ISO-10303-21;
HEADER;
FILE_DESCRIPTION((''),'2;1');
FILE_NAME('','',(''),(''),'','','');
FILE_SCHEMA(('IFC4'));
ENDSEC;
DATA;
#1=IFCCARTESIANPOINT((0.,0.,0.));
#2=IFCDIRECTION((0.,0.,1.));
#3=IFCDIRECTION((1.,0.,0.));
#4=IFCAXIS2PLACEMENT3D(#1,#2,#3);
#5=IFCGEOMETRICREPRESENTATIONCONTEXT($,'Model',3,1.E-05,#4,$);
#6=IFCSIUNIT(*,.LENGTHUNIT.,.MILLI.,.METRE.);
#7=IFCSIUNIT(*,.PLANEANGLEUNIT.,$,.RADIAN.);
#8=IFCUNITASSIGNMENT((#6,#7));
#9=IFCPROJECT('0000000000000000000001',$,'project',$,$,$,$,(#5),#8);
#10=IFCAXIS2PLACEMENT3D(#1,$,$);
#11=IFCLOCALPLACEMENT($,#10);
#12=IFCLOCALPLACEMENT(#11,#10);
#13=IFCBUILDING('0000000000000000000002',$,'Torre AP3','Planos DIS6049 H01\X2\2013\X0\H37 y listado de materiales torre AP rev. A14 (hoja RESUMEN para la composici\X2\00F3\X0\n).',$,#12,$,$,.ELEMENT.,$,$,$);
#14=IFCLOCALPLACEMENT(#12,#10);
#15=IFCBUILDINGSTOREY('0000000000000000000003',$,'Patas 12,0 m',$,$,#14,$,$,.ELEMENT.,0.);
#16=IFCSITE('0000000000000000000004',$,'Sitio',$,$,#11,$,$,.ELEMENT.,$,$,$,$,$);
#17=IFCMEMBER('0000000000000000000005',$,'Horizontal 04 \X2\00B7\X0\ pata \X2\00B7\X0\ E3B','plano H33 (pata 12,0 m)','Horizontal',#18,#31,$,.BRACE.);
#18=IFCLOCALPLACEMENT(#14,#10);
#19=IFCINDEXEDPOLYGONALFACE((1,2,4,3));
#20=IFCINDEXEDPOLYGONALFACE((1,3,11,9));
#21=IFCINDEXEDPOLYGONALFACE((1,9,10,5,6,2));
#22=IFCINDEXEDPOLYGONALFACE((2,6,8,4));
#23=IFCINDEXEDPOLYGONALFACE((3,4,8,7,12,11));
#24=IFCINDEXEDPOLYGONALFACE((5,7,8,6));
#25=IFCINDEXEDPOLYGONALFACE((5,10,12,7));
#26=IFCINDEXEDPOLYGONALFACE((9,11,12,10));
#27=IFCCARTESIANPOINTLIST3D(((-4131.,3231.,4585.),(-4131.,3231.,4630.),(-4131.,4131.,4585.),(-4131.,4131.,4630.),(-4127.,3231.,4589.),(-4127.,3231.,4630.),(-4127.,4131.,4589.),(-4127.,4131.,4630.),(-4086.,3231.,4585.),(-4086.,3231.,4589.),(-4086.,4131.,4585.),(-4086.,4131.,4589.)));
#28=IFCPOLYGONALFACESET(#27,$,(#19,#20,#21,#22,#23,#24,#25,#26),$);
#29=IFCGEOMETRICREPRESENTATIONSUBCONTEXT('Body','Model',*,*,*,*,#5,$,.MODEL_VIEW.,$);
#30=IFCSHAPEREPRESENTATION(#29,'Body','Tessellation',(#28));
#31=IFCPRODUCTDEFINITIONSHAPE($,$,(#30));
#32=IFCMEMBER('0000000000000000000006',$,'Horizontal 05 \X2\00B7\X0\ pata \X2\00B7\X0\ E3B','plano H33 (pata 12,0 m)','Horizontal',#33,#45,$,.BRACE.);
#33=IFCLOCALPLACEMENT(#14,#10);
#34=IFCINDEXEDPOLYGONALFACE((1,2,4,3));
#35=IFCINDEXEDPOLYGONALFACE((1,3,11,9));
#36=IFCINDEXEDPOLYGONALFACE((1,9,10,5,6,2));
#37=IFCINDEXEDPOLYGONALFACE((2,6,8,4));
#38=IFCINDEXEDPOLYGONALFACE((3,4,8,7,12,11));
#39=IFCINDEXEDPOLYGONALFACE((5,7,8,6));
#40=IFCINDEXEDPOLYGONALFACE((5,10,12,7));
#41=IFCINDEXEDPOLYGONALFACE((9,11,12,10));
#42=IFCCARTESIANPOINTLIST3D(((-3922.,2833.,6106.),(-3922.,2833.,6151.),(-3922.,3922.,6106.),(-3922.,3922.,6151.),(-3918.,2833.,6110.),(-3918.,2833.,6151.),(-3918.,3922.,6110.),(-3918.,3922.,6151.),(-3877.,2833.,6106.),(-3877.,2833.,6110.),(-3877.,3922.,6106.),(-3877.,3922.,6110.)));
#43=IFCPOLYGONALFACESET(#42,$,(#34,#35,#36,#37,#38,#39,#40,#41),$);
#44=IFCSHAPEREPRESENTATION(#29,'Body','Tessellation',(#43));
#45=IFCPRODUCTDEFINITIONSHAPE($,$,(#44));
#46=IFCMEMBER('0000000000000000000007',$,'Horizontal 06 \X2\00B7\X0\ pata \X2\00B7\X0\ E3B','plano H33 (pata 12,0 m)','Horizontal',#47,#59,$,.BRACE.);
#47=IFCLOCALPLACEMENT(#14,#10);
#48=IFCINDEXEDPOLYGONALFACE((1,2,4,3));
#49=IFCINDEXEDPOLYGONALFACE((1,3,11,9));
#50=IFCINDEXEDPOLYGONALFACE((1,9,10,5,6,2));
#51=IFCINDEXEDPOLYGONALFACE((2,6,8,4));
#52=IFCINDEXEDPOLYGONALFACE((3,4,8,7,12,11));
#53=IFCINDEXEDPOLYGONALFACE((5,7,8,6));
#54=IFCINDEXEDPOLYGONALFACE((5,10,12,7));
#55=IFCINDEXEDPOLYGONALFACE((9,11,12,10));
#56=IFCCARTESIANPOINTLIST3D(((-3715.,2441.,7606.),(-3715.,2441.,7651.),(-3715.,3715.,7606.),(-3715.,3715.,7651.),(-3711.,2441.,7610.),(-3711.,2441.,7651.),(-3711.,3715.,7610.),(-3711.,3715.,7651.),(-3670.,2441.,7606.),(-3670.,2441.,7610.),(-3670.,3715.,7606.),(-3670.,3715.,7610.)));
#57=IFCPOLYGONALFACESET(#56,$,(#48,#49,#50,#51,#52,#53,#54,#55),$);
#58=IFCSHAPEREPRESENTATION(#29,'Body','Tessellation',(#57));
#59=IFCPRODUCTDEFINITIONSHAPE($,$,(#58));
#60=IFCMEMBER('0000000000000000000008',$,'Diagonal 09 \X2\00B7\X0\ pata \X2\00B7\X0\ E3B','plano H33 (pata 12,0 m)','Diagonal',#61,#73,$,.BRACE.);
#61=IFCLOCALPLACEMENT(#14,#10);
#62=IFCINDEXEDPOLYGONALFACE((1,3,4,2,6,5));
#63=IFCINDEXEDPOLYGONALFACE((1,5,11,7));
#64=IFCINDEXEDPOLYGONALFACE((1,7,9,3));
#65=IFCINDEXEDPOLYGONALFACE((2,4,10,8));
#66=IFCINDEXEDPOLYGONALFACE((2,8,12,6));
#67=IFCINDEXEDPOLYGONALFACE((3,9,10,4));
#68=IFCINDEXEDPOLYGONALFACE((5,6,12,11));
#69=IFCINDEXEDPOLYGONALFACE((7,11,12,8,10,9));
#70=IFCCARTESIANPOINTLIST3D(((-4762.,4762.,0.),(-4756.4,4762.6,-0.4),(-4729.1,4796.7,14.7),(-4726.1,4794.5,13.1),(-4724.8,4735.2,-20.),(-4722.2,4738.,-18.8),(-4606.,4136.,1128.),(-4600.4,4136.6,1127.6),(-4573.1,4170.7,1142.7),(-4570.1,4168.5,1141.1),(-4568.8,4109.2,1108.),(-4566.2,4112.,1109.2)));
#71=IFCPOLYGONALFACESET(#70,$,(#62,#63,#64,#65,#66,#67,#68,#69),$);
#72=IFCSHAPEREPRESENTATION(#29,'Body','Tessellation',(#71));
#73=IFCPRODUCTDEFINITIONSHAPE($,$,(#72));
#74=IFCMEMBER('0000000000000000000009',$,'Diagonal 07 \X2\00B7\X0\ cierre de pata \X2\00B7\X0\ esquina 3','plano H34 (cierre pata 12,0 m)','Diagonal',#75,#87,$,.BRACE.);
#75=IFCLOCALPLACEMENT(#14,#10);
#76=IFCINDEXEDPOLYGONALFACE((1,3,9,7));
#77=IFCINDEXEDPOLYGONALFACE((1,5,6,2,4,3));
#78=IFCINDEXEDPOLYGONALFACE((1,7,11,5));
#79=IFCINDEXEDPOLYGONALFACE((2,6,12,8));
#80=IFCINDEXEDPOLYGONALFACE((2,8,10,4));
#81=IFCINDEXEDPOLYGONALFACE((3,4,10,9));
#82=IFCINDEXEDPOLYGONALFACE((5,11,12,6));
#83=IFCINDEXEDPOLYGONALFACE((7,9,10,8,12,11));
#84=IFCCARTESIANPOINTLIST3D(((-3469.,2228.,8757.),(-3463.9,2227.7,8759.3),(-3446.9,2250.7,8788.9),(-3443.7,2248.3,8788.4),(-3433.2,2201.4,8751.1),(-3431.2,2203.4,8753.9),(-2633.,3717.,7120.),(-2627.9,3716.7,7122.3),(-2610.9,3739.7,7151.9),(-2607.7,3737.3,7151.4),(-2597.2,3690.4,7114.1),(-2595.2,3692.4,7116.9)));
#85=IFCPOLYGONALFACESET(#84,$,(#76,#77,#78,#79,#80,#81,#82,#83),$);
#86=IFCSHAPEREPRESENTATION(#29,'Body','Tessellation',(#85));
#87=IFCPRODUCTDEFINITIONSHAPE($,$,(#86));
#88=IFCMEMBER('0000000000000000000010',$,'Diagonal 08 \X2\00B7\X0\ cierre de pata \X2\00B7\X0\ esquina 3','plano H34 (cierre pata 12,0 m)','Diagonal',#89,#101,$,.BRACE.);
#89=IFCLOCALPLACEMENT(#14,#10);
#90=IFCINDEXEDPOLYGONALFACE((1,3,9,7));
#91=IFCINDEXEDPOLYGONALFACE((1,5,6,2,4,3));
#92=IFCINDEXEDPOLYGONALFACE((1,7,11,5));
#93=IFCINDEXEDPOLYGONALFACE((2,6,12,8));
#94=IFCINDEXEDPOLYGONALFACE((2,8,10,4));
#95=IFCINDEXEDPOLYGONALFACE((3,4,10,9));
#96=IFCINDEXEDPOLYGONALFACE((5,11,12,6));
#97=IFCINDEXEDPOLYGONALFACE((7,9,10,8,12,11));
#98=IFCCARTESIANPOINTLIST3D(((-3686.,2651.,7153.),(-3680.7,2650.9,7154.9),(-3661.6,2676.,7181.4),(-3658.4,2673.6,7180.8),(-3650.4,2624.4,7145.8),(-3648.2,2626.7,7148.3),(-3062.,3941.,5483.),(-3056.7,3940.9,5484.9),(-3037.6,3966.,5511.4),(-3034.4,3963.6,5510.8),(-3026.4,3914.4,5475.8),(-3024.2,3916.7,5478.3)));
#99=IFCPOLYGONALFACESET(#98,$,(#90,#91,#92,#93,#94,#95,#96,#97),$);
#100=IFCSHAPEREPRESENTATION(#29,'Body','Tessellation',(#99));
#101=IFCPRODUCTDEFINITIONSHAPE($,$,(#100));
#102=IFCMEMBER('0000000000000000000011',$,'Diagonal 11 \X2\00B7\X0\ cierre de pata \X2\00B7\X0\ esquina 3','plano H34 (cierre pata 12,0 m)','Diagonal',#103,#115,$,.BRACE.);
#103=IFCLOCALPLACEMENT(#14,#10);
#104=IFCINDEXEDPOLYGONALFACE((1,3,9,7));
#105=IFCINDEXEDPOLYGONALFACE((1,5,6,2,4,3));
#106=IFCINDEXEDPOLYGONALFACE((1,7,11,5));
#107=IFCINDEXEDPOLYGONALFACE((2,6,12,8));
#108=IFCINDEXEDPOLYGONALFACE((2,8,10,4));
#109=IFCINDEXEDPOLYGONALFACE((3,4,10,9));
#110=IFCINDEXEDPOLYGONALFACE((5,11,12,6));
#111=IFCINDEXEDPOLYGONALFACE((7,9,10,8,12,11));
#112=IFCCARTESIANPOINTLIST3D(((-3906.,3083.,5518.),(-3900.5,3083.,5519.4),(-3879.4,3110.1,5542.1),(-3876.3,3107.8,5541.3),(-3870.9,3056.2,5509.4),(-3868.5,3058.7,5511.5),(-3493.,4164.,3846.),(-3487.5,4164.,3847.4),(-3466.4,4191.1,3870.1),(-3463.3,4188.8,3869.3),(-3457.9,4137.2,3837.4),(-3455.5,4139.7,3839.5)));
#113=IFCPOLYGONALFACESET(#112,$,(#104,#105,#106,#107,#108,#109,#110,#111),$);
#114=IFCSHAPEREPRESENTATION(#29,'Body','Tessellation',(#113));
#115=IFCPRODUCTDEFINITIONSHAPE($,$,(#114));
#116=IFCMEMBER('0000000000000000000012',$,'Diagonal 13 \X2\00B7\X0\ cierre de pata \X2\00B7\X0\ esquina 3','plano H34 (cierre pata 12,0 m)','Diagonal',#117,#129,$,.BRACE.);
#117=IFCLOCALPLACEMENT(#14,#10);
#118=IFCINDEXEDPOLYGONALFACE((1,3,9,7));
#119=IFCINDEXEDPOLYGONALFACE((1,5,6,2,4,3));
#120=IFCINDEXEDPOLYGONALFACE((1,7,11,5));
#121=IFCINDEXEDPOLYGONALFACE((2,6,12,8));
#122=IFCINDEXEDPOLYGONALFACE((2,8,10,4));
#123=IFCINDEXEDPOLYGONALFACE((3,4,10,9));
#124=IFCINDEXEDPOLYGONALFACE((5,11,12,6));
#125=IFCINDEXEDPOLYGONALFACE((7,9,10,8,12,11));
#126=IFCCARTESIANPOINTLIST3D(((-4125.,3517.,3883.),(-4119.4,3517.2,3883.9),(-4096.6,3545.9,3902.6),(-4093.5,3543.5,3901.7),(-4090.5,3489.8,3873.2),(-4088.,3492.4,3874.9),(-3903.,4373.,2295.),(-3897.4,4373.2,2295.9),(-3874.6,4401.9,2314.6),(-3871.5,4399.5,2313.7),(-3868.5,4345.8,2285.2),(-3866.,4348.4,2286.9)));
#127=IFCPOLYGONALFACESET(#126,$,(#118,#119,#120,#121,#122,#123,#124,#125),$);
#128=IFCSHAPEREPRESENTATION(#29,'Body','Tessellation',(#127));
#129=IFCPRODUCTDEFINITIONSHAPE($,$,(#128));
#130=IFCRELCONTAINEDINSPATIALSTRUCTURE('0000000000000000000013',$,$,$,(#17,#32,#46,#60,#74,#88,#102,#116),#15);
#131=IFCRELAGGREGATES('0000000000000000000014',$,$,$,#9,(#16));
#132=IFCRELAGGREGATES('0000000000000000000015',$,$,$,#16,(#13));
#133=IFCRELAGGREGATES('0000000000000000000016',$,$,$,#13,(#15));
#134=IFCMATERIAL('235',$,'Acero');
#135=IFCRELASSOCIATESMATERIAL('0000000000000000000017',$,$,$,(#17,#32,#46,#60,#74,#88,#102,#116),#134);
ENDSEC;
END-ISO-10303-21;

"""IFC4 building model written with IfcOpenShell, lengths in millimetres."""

from ifc_helpers import new_model, si_unit, frame, frame_2d, origin, origin_with_axes, place, context, subcontext, project, spatial, l_section, extrude, material, element, save


model = new_model("IFC4")

# Units and contexts
model_context = context("Model", 3, precision=1e-05, world=origin_with_axes())
body_context = subcontext(model_context, "Body", "Model", "MODEL_VIEW")
ifc_project = project(units=[si_unit("LENGTHUNIT", "METRE", prefix="MILLI"), si_unit("PLANEANGLEUNIT", "RADIAN")], contexts=[model_context])

# Site, building, storey
site_placement = place(None, origin())
site = spatial("IfcSite", under=ifc_project, at=site_placement, Name="Sitio", CompositionType="ELEMENT")
building_placement = place(site_placement, origin())
building = spatial("IfcBuilding", under=site, at=building_placement, Name="Torre AP3", Description="Planos DIS6049 H01–H37 y listado de materiales torre AP rev. A14 (hoja RESUMEN para la composición).", CompositionType="ELEMENT")
storey_placement = place(building_placement, origin())
storey = spatial("IfcBuildingStorey", under=building, at=storey_placement, Name="Patas 12,0 m", CompositionType="ELEMENT", Elevation=0.0)

# Members
ifc_material_1 = material(Name="235", Category="Acero")
member_1_placement = place(storey_placement, frame((-4131.0, 4131.0, 4585.0), z_axis=(0.0, -1.0, 0.0), x_axis=(1.0, 0.0, 0.0)))
element("IfcMember", 1, at=member_1_placement, inside=storey, material=ifc_material_1, Name="Horizontal 04 · pata · E3B", Description="plano H33 (pata 12,0 m)", ObjectType="Horizontal", PredefinedType="BRACE", context=body_context, shape_type="SweptSolid", body=[
    extrude(l_section(Depth=45.0, Width=45.0, Thickness=4.0, at=frame_2d((22.5, 22.5))), None, (0.0, 0.0, 1.0), 900.0),
])
member_2_placement = place(storey_placement, frame((-3922.0, 3922.0, 6106.0), z_axis=(0.0, -1.0, 0.0), x_axis=(1.0, 0.0, 0.0)))
element("IfcMember", 2, at=member_2_placement, inside=storey, material=ifc_material_1, Name="Horizontal 05 · pata · E3B", Description="plano H33 (pata 12,0 m)", ObjectType="Horizontal", PredefinedType="BRACE", context=body_context, shape_type="SweptSolid", body=[
    extrude(l_section(Depth=45.0, Width=45.0, Thickness=4.0, at=frame_2d((22.5, 22.5))), None, (0.0, 0.0, 1.0), 1089.0),
])
member_3_placement = place(storey_placement, frame((-3715.0, 3715.0, 7606.0), z_axis=(0.0, -1.0, 0.0), x_axis=(1.0, 0.0, 0.0)))
element("IfcMember", 3, at=member_3_placement, inside=storey, material=ifc_material_1, Name="Horizontal 06 · pata · E3B", Description="plano H33 (pata 12,0 m)", ObjectType="Horizontal", PredefinedType="BRACE", context=body_context, shape_type="SweptSolid", body=[
    extrude(l_section(Depth=45.0, Width=45.0, Thickness=4.0, at=frame_2d((22.5, 22.5))), None, (0.0, 0.0, 1.0), 1274.0),
])
member_4_placement = place(storey_placement, frame((-4762.0, 4762.0, 0.0), z_axis=(0.12005, -0.481739, 0.868053), x_axis=(0.743093, -0.53622, -0.400351)))
element("IfcMember", 4, at=member_4_placement, inside=storey, material=ifc_material_1, Name="Diagonal 09 · pata · E3B", Description="plano H33 (pata 12,0 m)", ObjectType="Diagonal", PredefinedType="BRACE", context=body_context, shape_type="SweptSolid", body=[
    extrude(l_section(Depth=50.0, Width=50.0, Thickness=4.0, at=frame_2d((25.0, 25.0))), None, (0.0, 0.0, 1.0), 1299.5),
])
member_5_placement = place(storey_placement, frame((-2633.0, 3717.0, 7120.0), z_axis=(-0.353407, -0.629454, 0.692019), x_axis=(0.795946, -0.591004, -0.13109)))
element("IfcMember", 5, at=member_5_placement, inside=storey, material=ifc_material_1, Name="Diagonal 07 · cierre de pata · esquina 3", Description="plano H34 (cierre pata 12,0 m)", ObjectType="Diagonal", PredefinedType="BRACE", context=body_context, shape_type="SweptSolid", body=[
    extrude(l_section(Depth=45.0, Width=45.0, Thickness=4.0, at=frame_2d((22.5, 22.5))), None, (0.0, 0.0, 1.0), 2365.5),
])
member_6_placement = place(storey_placement, frame((-3062.0, 3941.0, 5483.0), z_axis=(-0.283567, -0.58622, 0.758905), x_axis=(0.79107, -0.59032, -0.16041)))
element("IfcMember", 6, at=member_6_placement, inside=storey, material=ifc_material_1, Name="Diagonal 08 · cierre de pata · esquina 3", Description="plano H34 (cierre pata 12,0 m)", ObjectType="Diagonal", PredefinedType="BRACE", context=body_context, shape_type="SweptSolid", body=[
    extrude(l_section(Depth=45.0, Width=45.0, Thickness=4.0, at=frame_2d((22.5, 22.5))), None, (0.0, 0.0, 1.0), 2200.5),
])
member_7_placement = place(storey_placement, frame((-3493.0, 4164.0, 3846.0), z_axis=(-0.203108, -0.531622, 0.822268), x_axis=(0.780855, -0.594618, -0.191561)))
element("IfcMember", 7, at=member_7_placement, inside=storey, material=ifc_material_1, Name="Diagonal 11 · cierre de pata · esquina 3", Description="plano H34 (cierre pata 12,0 m)", ObjectType="Diagonal", PredefinedType="BRACE", context=body_context, shape_type="SweptSolid", body=[
    extrude(l_section(Depth=45.0, Width=45.0, Thickness=4.0, at=frame_2d((22.5, 22.5))), None, (0.0, 0.0, 1.0), 2033.4),
])
member_8_placement = place(storey_placement, frame((-3903.0, 4373.0, 2295.0), z_axis=(-0.122137, -0.470944, 0.873667), x_axis=(0.765844, -0.604634, -0.21886)))
element("IfcMember", 8, at=member_8_placement, inside=storey, material=ifc_material_1, Name="Diagonal 13 · cierre de pata · esquina 3", Description="plano H34 (cierre pata 12,0 m)", ObjectType="Diagonal", PredefinedType="BRACE", context=body_context, shape_type="SweptSolid", body=[
    extrude(l_section(Depth=45.0, Width=45.0, Thickness=4.0, at=frame_2d((22.5, 22.5))), None, (0.0, 0.0, 1.0), 1817.6),
])

save(model, "model.ifc")
